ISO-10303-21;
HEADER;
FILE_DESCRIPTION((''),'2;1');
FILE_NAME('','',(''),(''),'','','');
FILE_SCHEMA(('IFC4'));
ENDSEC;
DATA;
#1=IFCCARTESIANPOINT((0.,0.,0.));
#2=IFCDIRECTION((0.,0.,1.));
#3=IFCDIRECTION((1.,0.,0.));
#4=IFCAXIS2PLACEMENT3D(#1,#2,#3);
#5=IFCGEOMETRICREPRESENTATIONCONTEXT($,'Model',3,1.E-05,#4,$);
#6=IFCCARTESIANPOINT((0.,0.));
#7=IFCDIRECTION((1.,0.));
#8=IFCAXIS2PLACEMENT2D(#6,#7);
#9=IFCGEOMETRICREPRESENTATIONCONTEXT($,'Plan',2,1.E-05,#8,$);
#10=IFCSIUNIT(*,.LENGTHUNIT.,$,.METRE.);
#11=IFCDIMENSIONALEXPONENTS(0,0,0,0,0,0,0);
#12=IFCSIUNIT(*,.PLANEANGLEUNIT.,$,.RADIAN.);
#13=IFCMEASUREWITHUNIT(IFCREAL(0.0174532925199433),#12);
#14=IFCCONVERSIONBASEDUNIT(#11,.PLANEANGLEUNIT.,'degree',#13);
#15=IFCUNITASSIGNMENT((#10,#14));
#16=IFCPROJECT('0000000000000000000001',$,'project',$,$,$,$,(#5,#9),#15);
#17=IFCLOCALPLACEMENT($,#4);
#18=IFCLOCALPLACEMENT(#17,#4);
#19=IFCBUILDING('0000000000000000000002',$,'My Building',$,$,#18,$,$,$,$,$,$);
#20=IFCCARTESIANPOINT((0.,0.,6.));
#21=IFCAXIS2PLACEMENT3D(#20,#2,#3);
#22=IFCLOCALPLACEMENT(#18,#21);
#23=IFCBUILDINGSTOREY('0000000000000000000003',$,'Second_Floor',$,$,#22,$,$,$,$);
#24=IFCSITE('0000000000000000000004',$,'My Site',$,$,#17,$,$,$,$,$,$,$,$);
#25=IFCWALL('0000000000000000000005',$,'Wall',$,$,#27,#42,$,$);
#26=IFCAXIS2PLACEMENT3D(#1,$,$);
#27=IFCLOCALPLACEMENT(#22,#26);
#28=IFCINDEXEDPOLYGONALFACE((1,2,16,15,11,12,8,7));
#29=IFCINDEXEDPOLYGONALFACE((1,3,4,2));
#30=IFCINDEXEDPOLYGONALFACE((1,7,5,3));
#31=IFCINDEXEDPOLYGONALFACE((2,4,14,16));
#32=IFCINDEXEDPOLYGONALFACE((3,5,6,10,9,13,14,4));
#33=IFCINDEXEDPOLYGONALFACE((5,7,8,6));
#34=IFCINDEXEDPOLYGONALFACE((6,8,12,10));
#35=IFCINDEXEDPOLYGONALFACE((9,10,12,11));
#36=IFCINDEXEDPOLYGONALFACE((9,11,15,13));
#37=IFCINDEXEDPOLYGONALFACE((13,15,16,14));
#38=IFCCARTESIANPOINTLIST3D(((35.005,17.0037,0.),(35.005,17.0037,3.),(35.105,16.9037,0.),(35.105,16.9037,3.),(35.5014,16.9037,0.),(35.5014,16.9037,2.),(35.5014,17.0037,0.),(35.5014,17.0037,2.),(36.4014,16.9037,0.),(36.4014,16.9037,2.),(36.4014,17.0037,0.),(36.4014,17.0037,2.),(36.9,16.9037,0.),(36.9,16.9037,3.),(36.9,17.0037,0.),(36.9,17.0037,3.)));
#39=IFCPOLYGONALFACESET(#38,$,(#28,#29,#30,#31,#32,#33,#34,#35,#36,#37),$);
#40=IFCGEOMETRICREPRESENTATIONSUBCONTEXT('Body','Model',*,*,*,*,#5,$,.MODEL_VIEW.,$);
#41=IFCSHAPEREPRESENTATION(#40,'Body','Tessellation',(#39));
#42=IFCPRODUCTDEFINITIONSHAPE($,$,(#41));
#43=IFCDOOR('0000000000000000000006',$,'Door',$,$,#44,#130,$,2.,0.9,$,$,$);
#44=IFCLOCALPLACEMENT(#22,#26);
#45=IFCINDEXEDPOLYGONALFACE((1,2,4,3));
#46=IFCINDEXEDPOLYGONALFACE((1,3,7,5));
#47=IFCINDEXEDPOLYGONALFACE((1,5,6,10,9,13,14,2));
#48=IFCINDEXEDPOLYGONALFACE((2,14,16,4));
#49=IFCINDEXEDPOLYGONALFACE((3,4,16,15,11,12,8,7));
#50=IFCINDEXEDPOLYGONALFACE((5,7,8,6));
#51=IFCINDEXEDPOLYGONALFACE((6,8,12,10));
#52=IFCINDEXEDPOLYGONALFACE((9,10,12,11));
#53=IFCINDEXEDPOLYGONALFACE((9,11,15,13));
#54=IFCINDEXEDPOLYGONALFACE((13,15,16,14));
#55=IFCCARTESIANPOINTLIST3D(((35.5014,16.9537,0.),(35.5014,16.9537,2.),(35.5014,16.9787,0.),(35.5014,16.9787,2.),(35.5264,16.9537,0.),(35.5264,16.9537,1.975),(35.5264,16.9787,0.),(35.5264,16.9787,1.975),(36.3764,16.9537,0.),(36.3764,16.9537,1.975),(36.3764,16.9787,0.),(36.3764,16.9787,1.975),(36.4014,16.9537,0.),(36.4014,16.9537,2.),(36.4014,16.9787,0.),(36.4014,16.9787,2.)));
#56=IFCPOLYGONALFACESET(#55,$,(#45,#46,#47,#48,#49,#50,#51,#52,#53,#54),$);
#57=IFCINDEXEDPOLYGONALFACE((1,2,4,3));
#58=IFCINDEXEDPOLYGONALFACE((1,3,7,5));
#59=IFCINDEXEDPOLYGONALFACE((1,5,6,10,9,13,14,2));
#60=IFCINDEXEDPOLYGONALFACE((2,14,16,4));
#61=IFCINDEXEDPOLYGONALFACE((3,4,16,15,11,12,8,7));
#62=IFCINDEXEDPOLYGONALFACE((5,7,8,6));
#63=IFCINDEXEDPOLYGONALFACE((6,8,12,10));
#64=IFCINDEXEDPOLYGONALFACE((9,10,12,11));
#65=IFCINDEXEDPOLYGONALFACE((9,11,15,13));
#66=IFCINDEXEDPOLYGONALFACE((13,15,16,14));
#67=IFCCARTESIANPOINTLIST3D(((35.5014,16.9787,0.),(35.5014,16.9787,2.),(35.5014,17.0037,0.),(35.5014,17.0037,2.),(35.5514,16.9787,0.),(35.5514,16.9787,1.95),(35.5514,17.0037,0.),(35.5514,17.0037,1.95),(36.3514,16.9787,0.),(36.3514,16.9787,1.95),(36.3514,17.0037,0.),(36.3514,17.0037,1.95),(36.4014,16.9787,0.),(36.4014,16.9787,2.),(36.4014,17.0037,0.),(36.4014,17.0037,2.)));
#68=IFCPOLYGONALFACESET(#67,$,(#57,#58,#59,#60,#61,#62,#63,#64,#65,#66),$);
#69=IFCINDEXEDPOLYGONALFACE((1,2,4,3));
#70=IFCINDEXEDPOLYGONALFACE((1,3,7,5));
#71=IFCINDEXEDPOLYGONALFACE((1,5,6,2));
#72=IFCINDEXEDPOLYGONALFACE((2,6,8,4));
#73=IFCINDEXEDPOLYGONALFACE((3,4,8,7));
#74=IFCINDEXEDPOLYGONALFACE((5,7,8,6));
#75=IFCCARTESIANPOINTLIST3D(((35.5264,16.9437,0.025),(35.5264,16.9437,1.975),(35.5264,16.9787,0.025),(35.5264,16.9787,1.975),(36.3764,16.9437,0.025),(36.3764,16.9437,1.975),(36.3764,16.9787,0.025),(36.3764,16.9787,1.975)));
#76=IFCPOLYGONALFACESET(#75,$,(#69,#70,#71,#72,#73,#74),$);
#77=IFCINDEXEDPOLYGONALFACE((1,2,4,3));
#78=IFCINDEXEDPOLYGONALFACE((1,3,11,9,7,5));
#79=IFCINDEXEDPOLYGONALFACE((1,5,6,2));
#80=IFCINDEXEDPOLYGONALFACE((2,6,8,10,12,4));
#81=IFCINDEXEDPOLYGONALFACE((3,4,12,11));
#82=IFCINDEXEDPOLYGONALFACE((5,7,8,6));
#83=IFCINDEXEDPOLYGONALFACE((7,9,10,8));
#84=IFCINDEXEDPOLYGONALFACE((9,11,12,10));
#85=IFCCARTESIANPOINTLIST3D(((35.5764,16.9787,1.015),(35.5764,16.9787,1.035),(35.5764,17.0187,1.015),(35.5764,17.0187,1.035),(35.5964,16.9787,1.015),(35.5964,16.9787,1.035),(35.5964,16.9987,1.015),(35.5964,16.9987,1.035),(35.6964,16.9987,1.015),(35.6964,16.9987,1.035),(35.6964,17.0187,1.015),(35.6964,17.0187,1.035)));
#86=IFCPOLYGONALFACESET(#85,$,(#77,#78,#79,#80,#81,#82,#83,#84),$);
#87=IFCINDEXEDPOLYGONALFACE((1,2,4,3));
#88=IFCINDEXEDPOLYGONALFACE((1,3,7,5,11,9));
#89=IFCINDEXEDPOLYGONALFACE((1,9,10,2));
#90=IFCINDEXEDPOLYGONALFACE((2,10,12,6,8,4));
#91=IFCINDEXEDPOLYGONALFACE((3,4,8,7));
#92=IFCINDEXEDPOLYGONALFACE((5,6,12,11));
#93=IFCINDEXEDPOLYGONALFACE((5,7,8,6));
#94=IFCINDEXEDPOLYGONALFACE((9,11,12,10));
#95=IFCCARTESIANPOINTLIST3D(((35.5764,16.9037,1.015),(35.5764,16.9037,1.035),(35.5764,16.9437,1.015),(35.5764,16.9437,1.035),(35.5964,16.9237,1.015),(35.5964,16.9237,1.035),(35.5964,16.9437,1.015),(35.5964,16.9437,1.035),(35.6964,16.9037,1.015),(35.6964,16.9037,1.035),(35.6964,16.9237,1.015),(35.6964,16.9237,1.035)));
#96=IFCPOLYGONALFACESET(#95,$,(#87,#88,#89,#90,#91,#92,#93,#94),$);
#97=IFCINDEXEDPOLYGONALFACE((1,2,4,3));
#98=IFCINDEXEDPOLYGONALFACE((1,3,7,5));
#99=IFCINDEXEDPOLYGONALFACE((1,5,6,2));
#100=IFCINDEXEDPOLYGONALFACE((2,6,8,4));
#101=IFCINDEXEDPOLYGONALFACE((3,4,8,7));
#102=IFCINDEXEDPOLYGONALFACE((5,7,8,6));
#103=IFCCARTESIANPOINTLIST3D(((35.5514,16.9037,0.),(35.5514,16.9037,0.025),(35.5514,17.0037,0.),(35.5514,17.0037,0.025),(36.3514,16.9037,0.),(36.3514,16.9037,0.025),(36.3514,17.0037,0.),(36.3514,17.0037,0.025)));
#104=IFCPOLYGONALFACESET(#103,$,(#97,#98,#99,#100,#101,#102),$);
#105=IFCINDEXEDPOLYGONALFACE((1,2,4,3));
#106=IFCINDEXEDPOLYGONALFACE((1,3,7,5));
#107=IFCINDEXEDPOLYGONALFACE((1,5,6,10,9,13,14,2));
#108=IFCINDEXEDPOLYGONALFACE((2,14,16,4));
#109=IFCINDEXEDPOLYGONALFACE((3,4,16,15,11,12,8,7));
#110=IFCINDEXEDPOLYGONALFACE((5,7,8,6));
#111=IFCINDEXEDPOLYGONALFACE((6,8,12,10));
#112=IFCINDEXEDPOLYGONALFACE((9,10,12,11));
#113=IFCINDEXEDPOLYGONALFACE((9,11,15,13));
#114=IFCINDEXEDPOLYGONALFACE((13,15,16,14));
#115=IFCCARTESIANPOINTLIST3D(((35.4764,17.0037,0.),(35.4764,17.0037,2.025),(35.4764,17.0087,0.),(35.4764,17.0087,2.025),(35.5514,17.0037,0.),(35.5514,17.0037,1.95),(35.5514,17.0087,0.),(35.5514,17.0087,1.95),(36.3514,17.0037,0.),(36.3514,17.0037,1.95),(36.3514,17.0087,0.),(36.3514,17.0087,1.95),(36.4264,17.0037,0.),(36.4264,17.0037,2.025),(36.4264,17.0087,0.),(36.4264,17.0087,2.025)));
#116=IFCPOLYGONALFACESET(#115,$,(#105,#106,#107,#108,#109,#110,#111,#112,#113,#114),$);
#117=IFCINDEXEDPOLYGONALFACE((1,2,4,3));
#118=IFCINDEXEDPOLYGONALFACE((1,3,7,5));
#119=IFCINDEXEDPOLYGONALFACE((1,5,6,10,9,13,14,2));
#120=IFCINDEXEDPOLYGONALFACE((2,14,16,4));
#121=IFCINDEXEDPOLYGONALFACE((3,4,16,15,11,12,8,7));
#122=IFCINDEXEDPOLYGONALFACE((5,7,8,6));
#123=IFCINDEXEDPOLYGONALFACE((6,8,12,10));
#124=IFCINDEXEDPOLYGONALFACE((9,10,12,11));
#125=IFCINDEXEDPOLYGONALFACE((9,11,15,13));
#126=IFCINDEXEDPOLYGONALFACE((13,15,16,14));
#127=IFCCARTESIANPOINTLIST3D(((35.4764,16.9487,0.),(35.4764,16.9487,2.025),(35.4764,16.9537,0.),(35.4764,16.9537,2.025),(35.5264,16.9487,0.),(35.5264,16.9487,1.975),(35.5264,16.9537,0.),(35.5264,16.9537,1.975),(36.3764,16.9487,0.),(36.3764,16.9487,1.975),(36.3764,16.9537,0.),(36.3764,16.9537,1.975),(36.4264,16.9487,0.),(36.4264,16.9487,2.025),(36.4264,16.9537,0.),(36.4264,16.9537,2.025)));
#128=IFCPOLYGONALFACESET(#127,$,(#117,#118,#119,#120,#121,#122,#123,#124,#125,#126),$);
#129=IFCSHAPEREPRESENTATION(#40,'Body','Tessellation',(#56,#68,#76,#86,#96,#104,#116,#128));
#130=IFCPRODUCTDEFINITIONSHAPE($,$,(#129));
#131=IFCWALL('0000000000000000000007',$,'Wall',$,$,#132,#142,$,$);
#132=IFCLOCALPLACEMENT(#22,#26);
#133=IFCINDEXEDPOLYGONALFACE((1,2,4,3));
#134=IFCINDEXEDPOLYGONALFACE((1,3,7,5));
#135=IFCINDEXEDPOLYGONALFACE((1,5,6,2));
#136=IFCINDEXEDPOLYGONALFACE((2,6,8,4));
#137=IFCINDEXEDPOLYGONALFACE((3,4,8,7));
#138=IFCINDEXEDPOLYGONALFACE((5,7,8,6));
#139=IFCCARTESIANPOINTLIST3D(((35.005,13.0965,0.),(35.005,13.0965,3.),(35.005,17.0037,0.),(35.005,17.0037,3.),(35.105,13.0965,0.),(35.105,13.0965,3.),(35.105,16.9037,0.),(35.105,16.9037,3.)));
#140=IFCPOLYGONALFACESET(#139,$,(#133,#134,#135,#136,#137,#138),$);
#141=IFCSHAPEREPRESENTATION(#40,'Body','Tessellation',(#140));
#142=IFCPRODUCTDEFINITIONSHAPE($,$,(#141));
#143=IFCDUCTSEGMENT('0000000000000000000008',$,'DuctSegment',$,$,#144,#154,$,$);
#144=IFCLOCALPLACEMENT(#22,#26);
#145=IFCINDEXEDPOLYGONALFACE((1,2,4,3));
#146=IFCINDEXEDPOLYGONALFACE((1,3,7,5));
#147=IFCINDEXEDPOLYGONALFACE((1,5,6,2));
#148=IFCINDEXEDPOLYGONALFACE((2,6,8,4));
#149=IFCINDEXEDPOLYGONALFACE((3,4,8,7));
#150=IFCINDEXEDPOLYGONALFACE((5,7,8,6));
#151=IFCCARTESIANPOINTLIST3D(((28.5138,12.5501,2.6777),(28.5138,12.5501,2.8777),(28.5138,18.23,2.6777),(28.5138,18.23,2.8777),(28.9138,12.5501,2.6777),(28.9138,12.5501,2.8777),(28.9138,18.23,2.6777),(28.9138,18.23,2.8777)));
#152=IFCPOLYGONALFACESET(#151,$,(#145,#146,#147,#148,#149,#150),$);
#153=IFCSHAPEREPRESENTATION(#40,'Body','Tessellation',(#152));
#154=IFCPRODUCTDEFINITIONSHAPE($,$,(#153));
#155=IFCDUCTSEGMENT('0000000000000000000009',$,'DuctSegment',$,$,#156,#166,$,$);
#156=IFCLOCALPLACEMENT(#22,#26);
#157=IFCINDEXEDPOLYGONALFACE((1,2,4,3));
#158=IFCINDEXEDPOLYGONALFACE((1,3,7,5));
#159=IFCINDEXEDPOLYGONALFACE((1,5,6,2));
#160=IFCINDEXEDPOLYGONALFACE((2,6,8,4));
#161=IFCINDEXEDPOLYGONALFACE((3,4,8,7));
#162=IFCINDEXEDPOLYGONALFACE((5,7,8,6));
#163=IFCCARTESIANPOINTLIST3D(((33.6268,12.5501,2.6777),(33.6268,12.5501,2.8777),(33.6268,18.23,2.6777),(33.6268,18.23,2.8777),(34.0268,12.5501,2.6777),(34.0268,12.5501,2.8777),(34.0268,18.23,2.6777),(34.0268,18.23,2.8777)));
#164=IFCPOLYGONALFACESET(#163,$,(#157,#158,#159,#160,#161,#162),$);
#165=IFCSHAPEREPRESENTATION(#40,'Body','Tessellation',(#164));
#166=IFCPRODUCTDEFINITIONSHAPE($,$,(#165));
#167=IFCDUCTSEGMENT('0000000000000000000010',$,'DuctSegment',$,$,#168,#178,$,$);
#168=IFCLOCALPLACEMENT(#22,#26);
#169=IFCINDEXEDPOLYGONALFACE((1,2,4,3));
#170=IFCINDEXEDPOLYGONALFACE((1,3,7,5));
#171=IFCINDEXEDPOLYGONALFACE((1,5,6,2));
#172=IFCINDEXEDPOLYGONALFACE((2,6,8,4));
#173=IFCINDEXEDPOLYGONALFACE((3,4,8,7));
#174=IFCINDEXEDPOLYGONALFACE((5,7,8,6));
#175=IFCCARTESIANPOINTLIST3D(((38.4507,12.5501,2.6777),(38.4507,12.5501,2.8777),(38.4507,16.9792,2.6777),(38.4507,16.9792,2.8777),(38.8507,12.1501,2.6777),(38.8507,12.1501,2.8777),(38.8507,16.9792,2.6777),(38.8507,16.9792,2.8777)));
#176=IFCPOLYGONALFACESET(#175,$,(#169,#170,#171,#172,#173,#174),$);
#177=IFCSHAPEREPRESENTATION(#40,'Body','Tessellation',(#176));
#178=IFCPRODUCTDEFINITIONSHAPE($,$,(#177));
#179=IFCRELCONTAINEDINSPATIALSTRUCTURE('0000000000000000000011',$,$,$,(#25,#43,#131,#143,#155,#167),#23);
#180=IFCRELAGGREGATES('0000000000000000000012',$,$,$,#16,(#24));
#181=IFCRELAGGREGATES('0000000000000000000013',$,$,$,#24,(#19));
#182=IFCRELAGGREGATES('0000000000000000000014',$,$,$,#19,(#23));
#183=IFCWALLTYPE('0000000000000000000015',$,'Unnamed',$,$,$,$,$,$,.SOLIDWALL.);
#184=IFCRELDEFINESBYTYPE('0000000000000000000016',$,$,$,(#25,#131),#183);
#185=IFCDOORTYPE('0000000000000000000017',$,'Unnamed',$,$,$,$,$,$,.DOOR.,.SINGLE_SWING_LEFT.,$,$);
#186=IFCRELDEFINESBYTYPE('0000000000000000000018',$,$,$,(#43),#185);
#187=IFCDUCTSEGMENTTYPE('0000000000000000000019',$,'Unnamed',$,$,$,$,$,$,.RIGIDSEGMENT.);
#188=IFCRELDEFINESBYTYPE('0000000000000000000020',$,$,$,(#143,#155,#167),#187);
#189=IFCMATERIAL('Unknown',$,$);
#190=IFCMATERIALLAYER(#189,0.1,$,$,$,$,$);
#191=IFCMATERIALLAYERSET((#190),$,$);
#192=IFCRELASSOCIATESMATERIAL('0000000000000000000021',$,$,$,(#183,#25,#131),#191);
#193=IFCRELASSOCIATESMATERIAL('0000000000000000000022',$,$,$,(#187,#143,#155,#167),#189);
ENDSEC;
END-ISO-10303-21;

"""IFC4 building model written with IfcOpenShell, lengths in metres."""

from ifc_helpers import new_model, entity, si_unit, converted_unit, frame, origin_with_axes, origin_2d_with_axis, place, context, subcontext, project, spatial, line, indexed_curve, rectangle, outline, extrude, clip, halfspace, shape, source, transform, mapped, material, layer, layer_set, layer_usage, material_profile, profile_set, profile_usage, type_object, type_shapes, element, fill, save


model = new_model("IFC4")

# Units and contexts
model_context = context("Model", 3, precision=1e-05, world=origin_with_axes())
plan_context = context("Plan", 2, precision=1e-05, world=origin_2d_with_axis())
body_context_1 = subcontext(model_context, "Body", "Model", "MODEL_VIEW")
body_context_2 = subcontext(plan_context, "Body", "Plan", "PLAN_VIEW")
ifc_project = project(units=[si_unit("LENGTHUNIT", "METRE"), converted_unit("PLANEANGLEUNIT", "degree", entity("IfcReal", 0.0174532925199433), si_unit("PLANEANGLEUNIT", "RADIAN"), dimensions=[0, 0, 0, 0, 0, 0, 0])], contexts=[model_context, plan_context])

# Site, building, storey
site_placement = place(None, origin_with_axes())
site = spatial("IfcSite", under=ifc_project, at=site_placement, Name="My Site")
building_placement = place(site_placement, origin_with_axes())
building = spatial("IfcBuilding", under=site, at=building_placement, Name="My Building")
storey_placement = place(building_placement, frame((0.0, 0.0, 6.0), z_axis=(0.0, 0.0, 1.0), x_axis=(1.0, 0.0, 0.0)))
storey = spatial("IfcBuildingStorey", under=building, at=storey_placement, Name="Second_Floor")

# Shared definitions
ifc_material = material(Name="Unknown")
ifc_layer = layer(ifc_material, 0.1)
ifc_layer_set = layer_set([ifc_layer])
wall_type = type_object("IfcWallType", Name="Unnamed", PredefinedType="SOLIDWALL", material=ifc_layer_set)

# Shared definitions
shared_shape_1 = source(origin_with_axes(), body_context_1, "Body", "SweptSolid", [
    extrude(outline(indexed_curve([(0.0, 0.0), (0.9, 0.0), (0.9, 2.0), (0.0, 2.0)], segments=[line(1, 2, 3, 4, 1)])), frame((0.0, -0.6, 0.0), z_axis=(0.0, -1.0, 0.0), x_axis=(1.0, 0.0, 0.0)), (0.0, 0.0, -1.0), 1.2),
])
door_type = type_object("IfcDoorType", Name="Unnamed", OperationType="SINGLE_SWING_LEFT", PredefinedType="DOOR")
shared_shape_2 = source(origin_with_axes(), body_context_1, "Body", "SweptSolid", [
    extrude(outline(indexed_curve([(0.0, 0.0), (0.0, 2.0), (0.9, 2.0), (0.9, 0.0), (0.875, 0.0), (0.875, 1.975), (0.025, 1.975), (0.025, 0.0)], segments=[line(1, 2, 3, 4, 5, 6, 7, 8, 1)])), frame((0.0, 0.025, 0.0), z_axis=(0.0, -1.0, 0.0), x_axis=(1.0, 0.0, 0.0)), (0.0, 0.0, -1.0), 0.025),
    extrude(outline(indexed_curve([(0.0, 0.0), (0.0, 2.0), (0.9, 2.0), (0.9, 0.0), (0.85, 0.0), (0.85, 1.95), (0.05, 1.95), (0.05, 0.0)], segments=[line(1, 2, 3, 4, 5, 6, 7, 8, 1)])), frame((0.0, 0.0, 0.0), z_axis=(0.0, -1.0, 0.0), x_axis=(1.0, 0.0, 0.0)), (0.0, 0.0, -1.0), 0.025),
    extrude(outline(indexed_curve([(0.0, 0.0), (0.85, 0.0), (0.85, 0.035), (0.0, 0.035)], segments=[line(1, 2, 3, 4, 1)])), frame((0.025, 0.025, 0.025), z_axis=(0.0, 0.0, 1.0), x_axis=(1.0, 0.0, 0.0)), (0.0, 0.0, 1.0), 1.95),
    extrude(outline(indexed_curve([(0.0, 0.0), (0.0, -0.04), (-0.12, -0.04), (-0.12, -0.02), (-0.02, -0.02), (-0.02, 0.0)], segments=[line(1, 2, 3, 4, 5, 6, 1)])), frame((0.825, 0.025, 1.015), z_axis=(0.0, 0.0, 1.0), x_axis=(1.0, 0.0, 0.0)), (0.0, 0.0, 1.0), 0.02),
    extrude(outline(indexed_curve([(0.0, 0.0), (0.0, 0.04), (-0.12, 0.04), (-0.12, 0.02), (-0.02, 0.02), (-0.02, 0.0)], segments=[line(1, 2, 3, 4, 5, 6, 1)])), frame((0.825, 0.06, 1.015), z_axis=(0.0, 0.0, 1.0), x_axis=(1.0, 0.0, 0.0)), (0.0, 0.0, 1.0), 0.02),
    extrude(outline(indexed_curve([(0.0, 0.0), (0.8, 0.0), (0.8, 0.1), (0.0, 0.1)], segments=[line(1, 2, 3, 4, 1)])), frame((0.05, 0.0, 0.0), z_axis=(0.0, 0.0, 1.0), x_axis=(1.0, 0.0, 0.0)), (0.0, 0.0, 1.0), 0.025),
    extrude(outline(indexed_curve([(0.0, 0.0), (0.0, 2.025), (0.95, 2.025), (0.95, 0.0), (0.875, 0.0), (0.875, 1.95), (0.075, 1.95), (0.075, 0.0)], segments=[line(1, 2, 3, 4, 5, 6, 7, 8, 1)])), frame((-0.025, -0.005, 0.0), z_axis=(0.0, -1.0, 0.0), x_axis=(1.0, 0.0, 0.0)), (0.0, 0.0, -1.0), 0.005),
    extrude(outline(indexed_curve([(0.0, 0.0), (0.0, 2.025), (0.95, 2.025), (0.95, 0.0), (0.9, 0.0), (0.9, 1.975), (0.05, 1.975), (0.05, 0.0)], segments=[line(1, 2, 3, 4, 5, 6, 7, 8, 1)])), frame((-0.025, 0.05, 0.0), z_axis=(0.0, -1.0, 0.0), x_axis=(1.0, 0.0, 0.0)), (0.0, 0.0, -1.0), 0.005),
])
shared_shape_3 = source(origin_with_axes(), body_context_2, "Body", "Curve2D", [
    entity("IfcIndexedPolyCurve", entity("IfcCartesianPointList2D", [[0.0, 0.0], [0.0, 0.05], [0.025, 0.05], [0.025, 0.025], [0.05, 0.025], [0.05, 0.0]]), [entity("IfcLineIndex", [1, 2, 3, 4, 5, 6, 1])]),
    entity("IfcIndexedPolyCurve", entity("IfcCartesianPointList2D", [[0.9, 0.0], [0.9, 0.05], [0.875, 0.05], [0.875, 0.025], [0.85, 0.025], [0.85, 0.0]]), [entity("IfcLineIndex", [1, 2, 3, 4, 5, 6, 1])]),
    entity("IfcTrimmedCurve", entity("IfcEllipse", entity("IfcAxis2Placement2D", entity("IfcCartesianPoint", [0.06, 0.05]), entity("IfcDirection", [1.0, 0.0])), 0.815, 0.85), [entity("IfcCartesianPoint", [0.875, 0.05])], [entity("IfcCartesianPoint", [0.06, 0.9])], True, "CARTESIAN"),
    entity("IfcIndexedPolyCurve", entity("IfcCartesianPointList2D", [[0.025, 0.05], [0.06, 0.05], [0.06, 0.9], [0.025, 0.9]]), [entity("IfcLineIndex", [1, 2, 3, 4, 1])]),
])
type_shapes(door_type, [shared_shape_2, shared_shape_3])

# Wall, opening, door
ifc_layer_usage_1 = layer_usage(ifc_layer_set, "AXIS2", "POSITIVE", 0.0)
wall_1_placement = place(storey_placement, frame((36.9, 17.0037, 0.0), z_axis=(0.0, 0.0, 1.0), x_axis=(-1.0, 0.0, 0.0)))
wall_1 = element("IfcWall", 1, at=wall_1_placement, inside=storey, type_object=wall_type, material=ifc_layer_usage_1, Name="Wall", context=body_context_1, shape_type="SweptSolid", body=[
    extrude(outline(indexed_curve([(0.0, 0.0), (0.0, 0.1), (1.795, 0.1), (1.895, 0.0)], segments=[line(1, 2, 3, 4, 1)])), origin_with_axes(), (0.0, 0.0, 1.0), 3.0),
])
opening_1_placement = place(wall_1_placement, frame((0.4986, 0.0, 0.0), z_axis=(0.0, 0.0, 1.0), x_axis=(1.0, 0.0, 0.0)))
opening_1 = element("IfcOpeningElement", 2, at=opening_1_placement, cuts=wall_1, PredefinedType="OPENING", context=body_context_1, shape_type="MappedRepresentation", body=[
    mapped(shared_shape_1, transform((0.0, 0.0, 0.0), x_axis=(1.0, 0.0, 0.0), y_axis=(0.0, 1.0, 0.0), z_axis=(0.0, 0.0, 1.0), scale=1.0)),
])
door_1_placement = place(opening_1_placement, frame((0.0, 0.0, 0.0), z_axis=(0.0, 0.0, 1.0), x_axis=(1.0, 0.0, 0.0)))
door_1 = element("IfcDoor", 3, at=door_1_placement, inside=storey, type_object=door_type, Name="Door", OverallHeight=2.0, OverallWidth=0.9, shapes=[
    shape(body_context_1, "Body", "MappedRepresentation", [mapped(shared_shape_2, transform((0.0, 0.0, 0.0), x_axis=(1.0, 0.0, 0.0), y_axis=(0.0, 1.0, 0.0), z_axis=(0.0, 0.0, 1.0), scale=1.0))]),
    shape(body_context_2, "Body", "MappedRepresentation", [mapped(shared_shape_3, transform((0.0, 0.0, 0.0), x_axis=(1.0, 0.0, 0.0), y_axis=(0.0, 1.0, 0.0), z_axis=(0.0, 0.0, 1.0), scale=1.0))]),
])
fill(opening_1, door_1)

# Wall
ifc_layer_usage_2 = layer_usage(ifc_layer_set, "AXIS2", "POSITIVE", 0.0)
wall_2_placement = place(storey_placement, frame((35.005, 17.0037, 0.0), z_axis=(0.0, 0.0, 1.0), x_axis=(0.0, -1.0, 0.0)))
element("IfcWall", 4, at=wall_2_placement, inside=storey, type_object=wall_type, material=ifc_layer_usage_2, Name="Wall", context=body_context_1, shape_type="SweptSolid", body=[
    extrude(outline(indexed_curve([(0.0, 0.0), (0.1, 0.1), (3.9072, 0.1), (3.9072, 0.0)], segments=[line(1, 2, 3, 4, 1)])), origin_with_axes(), (0.0, 0.0, 1.0), 3.0),
])

# Duct segments
ifc_material_profile_1 = material_profile(ifc_material, rectangle(XDim=0.4, YDim=0.2))
ifc_profile_set_1 = profile_set([ifc_material_profile_1])
ifc_profile_usage_1 = profile_usage(ifc_profile_set_1, cardinal=5)
duct_segment_type = type_object("IfcDuctSegmentType", Name="Unnamed", PredefinedType="RIGIDSEGMENT", material=ifc_profile_set_1)
duct_segment_1_placement = place(storey_placement, frame((28.7138, 12.5501, 2.7777), z_axis=(0.0, 1.0, 0.0), x_axis=(-1.0, 0.0, 0.0)))
element("IfcDuctSegment", 5, at=duct_segment_1_placement, inside=storey, type_object=duct_segment_type, material=ifc_profile_usage_1, Name="DuctSegment", context=body_context_1, shape_type="SweptSolid", body=[
    extrude(rectangle(XDim=0.4, YDim=0.2), origin_with_axes(), (0.0, 0.0, 1.0), 5.6799),
])
ifc_profile_usage_2 = profile_usage(ifc_profile_set_1, cardinal=5)
duct_segment_2_placement = place(storey_placement, frame((33.8268, 12.5501, 2.7777), z_axis=(0.0, 1.0, 0.0), x_axis=(-1.0, 0.0, 0.0)))
element("IfcDuctSegment", 6, at=duct_segment_2_placement, inside=storey, type_object=duct_segment_type, material=ifc_profile_usage_2, Name="DuctSegment", context=body_context_1, shape_type="SweptSolid", body=[
    extrude(rectangle(XDim=0.4, YDim=0.2), origin_with_axes(), (0.0, 0.0, 1.0), 5.6799),
])
ifc_profile_usage_3 = profile_usage(ifc_profile_set_1, cardinal=5)
duct_segment_3_placement = place(storey_placement, frame((38.6507, 12.1501, 2.7777), z_axis=(0.0, 1.0, 0.0), x_axis=(-1.0, 0.0, 0.0)))
element("IfcDuctSegment", 7, at=duct_segment_3_placement, inside=storey, type_object=duct_segment_type, material=ifc_profile_usage_3, Name="DuctSegment", context=body_context_1, shape_type="Clipping", body=[
    clip(extrude(rectangle(XDim=0.4, YDim=0.2), origin_with_axes(), (0.0, 0.0, 1.0), 4.8291), halfspace(frame((-0.2, -3.0, 0.0), z_axis=(0.707106, 0.0, -0.707109), x_axis=(0.0, -1.0, 0.0)), False)),
])

save(model, "model.ifc")
